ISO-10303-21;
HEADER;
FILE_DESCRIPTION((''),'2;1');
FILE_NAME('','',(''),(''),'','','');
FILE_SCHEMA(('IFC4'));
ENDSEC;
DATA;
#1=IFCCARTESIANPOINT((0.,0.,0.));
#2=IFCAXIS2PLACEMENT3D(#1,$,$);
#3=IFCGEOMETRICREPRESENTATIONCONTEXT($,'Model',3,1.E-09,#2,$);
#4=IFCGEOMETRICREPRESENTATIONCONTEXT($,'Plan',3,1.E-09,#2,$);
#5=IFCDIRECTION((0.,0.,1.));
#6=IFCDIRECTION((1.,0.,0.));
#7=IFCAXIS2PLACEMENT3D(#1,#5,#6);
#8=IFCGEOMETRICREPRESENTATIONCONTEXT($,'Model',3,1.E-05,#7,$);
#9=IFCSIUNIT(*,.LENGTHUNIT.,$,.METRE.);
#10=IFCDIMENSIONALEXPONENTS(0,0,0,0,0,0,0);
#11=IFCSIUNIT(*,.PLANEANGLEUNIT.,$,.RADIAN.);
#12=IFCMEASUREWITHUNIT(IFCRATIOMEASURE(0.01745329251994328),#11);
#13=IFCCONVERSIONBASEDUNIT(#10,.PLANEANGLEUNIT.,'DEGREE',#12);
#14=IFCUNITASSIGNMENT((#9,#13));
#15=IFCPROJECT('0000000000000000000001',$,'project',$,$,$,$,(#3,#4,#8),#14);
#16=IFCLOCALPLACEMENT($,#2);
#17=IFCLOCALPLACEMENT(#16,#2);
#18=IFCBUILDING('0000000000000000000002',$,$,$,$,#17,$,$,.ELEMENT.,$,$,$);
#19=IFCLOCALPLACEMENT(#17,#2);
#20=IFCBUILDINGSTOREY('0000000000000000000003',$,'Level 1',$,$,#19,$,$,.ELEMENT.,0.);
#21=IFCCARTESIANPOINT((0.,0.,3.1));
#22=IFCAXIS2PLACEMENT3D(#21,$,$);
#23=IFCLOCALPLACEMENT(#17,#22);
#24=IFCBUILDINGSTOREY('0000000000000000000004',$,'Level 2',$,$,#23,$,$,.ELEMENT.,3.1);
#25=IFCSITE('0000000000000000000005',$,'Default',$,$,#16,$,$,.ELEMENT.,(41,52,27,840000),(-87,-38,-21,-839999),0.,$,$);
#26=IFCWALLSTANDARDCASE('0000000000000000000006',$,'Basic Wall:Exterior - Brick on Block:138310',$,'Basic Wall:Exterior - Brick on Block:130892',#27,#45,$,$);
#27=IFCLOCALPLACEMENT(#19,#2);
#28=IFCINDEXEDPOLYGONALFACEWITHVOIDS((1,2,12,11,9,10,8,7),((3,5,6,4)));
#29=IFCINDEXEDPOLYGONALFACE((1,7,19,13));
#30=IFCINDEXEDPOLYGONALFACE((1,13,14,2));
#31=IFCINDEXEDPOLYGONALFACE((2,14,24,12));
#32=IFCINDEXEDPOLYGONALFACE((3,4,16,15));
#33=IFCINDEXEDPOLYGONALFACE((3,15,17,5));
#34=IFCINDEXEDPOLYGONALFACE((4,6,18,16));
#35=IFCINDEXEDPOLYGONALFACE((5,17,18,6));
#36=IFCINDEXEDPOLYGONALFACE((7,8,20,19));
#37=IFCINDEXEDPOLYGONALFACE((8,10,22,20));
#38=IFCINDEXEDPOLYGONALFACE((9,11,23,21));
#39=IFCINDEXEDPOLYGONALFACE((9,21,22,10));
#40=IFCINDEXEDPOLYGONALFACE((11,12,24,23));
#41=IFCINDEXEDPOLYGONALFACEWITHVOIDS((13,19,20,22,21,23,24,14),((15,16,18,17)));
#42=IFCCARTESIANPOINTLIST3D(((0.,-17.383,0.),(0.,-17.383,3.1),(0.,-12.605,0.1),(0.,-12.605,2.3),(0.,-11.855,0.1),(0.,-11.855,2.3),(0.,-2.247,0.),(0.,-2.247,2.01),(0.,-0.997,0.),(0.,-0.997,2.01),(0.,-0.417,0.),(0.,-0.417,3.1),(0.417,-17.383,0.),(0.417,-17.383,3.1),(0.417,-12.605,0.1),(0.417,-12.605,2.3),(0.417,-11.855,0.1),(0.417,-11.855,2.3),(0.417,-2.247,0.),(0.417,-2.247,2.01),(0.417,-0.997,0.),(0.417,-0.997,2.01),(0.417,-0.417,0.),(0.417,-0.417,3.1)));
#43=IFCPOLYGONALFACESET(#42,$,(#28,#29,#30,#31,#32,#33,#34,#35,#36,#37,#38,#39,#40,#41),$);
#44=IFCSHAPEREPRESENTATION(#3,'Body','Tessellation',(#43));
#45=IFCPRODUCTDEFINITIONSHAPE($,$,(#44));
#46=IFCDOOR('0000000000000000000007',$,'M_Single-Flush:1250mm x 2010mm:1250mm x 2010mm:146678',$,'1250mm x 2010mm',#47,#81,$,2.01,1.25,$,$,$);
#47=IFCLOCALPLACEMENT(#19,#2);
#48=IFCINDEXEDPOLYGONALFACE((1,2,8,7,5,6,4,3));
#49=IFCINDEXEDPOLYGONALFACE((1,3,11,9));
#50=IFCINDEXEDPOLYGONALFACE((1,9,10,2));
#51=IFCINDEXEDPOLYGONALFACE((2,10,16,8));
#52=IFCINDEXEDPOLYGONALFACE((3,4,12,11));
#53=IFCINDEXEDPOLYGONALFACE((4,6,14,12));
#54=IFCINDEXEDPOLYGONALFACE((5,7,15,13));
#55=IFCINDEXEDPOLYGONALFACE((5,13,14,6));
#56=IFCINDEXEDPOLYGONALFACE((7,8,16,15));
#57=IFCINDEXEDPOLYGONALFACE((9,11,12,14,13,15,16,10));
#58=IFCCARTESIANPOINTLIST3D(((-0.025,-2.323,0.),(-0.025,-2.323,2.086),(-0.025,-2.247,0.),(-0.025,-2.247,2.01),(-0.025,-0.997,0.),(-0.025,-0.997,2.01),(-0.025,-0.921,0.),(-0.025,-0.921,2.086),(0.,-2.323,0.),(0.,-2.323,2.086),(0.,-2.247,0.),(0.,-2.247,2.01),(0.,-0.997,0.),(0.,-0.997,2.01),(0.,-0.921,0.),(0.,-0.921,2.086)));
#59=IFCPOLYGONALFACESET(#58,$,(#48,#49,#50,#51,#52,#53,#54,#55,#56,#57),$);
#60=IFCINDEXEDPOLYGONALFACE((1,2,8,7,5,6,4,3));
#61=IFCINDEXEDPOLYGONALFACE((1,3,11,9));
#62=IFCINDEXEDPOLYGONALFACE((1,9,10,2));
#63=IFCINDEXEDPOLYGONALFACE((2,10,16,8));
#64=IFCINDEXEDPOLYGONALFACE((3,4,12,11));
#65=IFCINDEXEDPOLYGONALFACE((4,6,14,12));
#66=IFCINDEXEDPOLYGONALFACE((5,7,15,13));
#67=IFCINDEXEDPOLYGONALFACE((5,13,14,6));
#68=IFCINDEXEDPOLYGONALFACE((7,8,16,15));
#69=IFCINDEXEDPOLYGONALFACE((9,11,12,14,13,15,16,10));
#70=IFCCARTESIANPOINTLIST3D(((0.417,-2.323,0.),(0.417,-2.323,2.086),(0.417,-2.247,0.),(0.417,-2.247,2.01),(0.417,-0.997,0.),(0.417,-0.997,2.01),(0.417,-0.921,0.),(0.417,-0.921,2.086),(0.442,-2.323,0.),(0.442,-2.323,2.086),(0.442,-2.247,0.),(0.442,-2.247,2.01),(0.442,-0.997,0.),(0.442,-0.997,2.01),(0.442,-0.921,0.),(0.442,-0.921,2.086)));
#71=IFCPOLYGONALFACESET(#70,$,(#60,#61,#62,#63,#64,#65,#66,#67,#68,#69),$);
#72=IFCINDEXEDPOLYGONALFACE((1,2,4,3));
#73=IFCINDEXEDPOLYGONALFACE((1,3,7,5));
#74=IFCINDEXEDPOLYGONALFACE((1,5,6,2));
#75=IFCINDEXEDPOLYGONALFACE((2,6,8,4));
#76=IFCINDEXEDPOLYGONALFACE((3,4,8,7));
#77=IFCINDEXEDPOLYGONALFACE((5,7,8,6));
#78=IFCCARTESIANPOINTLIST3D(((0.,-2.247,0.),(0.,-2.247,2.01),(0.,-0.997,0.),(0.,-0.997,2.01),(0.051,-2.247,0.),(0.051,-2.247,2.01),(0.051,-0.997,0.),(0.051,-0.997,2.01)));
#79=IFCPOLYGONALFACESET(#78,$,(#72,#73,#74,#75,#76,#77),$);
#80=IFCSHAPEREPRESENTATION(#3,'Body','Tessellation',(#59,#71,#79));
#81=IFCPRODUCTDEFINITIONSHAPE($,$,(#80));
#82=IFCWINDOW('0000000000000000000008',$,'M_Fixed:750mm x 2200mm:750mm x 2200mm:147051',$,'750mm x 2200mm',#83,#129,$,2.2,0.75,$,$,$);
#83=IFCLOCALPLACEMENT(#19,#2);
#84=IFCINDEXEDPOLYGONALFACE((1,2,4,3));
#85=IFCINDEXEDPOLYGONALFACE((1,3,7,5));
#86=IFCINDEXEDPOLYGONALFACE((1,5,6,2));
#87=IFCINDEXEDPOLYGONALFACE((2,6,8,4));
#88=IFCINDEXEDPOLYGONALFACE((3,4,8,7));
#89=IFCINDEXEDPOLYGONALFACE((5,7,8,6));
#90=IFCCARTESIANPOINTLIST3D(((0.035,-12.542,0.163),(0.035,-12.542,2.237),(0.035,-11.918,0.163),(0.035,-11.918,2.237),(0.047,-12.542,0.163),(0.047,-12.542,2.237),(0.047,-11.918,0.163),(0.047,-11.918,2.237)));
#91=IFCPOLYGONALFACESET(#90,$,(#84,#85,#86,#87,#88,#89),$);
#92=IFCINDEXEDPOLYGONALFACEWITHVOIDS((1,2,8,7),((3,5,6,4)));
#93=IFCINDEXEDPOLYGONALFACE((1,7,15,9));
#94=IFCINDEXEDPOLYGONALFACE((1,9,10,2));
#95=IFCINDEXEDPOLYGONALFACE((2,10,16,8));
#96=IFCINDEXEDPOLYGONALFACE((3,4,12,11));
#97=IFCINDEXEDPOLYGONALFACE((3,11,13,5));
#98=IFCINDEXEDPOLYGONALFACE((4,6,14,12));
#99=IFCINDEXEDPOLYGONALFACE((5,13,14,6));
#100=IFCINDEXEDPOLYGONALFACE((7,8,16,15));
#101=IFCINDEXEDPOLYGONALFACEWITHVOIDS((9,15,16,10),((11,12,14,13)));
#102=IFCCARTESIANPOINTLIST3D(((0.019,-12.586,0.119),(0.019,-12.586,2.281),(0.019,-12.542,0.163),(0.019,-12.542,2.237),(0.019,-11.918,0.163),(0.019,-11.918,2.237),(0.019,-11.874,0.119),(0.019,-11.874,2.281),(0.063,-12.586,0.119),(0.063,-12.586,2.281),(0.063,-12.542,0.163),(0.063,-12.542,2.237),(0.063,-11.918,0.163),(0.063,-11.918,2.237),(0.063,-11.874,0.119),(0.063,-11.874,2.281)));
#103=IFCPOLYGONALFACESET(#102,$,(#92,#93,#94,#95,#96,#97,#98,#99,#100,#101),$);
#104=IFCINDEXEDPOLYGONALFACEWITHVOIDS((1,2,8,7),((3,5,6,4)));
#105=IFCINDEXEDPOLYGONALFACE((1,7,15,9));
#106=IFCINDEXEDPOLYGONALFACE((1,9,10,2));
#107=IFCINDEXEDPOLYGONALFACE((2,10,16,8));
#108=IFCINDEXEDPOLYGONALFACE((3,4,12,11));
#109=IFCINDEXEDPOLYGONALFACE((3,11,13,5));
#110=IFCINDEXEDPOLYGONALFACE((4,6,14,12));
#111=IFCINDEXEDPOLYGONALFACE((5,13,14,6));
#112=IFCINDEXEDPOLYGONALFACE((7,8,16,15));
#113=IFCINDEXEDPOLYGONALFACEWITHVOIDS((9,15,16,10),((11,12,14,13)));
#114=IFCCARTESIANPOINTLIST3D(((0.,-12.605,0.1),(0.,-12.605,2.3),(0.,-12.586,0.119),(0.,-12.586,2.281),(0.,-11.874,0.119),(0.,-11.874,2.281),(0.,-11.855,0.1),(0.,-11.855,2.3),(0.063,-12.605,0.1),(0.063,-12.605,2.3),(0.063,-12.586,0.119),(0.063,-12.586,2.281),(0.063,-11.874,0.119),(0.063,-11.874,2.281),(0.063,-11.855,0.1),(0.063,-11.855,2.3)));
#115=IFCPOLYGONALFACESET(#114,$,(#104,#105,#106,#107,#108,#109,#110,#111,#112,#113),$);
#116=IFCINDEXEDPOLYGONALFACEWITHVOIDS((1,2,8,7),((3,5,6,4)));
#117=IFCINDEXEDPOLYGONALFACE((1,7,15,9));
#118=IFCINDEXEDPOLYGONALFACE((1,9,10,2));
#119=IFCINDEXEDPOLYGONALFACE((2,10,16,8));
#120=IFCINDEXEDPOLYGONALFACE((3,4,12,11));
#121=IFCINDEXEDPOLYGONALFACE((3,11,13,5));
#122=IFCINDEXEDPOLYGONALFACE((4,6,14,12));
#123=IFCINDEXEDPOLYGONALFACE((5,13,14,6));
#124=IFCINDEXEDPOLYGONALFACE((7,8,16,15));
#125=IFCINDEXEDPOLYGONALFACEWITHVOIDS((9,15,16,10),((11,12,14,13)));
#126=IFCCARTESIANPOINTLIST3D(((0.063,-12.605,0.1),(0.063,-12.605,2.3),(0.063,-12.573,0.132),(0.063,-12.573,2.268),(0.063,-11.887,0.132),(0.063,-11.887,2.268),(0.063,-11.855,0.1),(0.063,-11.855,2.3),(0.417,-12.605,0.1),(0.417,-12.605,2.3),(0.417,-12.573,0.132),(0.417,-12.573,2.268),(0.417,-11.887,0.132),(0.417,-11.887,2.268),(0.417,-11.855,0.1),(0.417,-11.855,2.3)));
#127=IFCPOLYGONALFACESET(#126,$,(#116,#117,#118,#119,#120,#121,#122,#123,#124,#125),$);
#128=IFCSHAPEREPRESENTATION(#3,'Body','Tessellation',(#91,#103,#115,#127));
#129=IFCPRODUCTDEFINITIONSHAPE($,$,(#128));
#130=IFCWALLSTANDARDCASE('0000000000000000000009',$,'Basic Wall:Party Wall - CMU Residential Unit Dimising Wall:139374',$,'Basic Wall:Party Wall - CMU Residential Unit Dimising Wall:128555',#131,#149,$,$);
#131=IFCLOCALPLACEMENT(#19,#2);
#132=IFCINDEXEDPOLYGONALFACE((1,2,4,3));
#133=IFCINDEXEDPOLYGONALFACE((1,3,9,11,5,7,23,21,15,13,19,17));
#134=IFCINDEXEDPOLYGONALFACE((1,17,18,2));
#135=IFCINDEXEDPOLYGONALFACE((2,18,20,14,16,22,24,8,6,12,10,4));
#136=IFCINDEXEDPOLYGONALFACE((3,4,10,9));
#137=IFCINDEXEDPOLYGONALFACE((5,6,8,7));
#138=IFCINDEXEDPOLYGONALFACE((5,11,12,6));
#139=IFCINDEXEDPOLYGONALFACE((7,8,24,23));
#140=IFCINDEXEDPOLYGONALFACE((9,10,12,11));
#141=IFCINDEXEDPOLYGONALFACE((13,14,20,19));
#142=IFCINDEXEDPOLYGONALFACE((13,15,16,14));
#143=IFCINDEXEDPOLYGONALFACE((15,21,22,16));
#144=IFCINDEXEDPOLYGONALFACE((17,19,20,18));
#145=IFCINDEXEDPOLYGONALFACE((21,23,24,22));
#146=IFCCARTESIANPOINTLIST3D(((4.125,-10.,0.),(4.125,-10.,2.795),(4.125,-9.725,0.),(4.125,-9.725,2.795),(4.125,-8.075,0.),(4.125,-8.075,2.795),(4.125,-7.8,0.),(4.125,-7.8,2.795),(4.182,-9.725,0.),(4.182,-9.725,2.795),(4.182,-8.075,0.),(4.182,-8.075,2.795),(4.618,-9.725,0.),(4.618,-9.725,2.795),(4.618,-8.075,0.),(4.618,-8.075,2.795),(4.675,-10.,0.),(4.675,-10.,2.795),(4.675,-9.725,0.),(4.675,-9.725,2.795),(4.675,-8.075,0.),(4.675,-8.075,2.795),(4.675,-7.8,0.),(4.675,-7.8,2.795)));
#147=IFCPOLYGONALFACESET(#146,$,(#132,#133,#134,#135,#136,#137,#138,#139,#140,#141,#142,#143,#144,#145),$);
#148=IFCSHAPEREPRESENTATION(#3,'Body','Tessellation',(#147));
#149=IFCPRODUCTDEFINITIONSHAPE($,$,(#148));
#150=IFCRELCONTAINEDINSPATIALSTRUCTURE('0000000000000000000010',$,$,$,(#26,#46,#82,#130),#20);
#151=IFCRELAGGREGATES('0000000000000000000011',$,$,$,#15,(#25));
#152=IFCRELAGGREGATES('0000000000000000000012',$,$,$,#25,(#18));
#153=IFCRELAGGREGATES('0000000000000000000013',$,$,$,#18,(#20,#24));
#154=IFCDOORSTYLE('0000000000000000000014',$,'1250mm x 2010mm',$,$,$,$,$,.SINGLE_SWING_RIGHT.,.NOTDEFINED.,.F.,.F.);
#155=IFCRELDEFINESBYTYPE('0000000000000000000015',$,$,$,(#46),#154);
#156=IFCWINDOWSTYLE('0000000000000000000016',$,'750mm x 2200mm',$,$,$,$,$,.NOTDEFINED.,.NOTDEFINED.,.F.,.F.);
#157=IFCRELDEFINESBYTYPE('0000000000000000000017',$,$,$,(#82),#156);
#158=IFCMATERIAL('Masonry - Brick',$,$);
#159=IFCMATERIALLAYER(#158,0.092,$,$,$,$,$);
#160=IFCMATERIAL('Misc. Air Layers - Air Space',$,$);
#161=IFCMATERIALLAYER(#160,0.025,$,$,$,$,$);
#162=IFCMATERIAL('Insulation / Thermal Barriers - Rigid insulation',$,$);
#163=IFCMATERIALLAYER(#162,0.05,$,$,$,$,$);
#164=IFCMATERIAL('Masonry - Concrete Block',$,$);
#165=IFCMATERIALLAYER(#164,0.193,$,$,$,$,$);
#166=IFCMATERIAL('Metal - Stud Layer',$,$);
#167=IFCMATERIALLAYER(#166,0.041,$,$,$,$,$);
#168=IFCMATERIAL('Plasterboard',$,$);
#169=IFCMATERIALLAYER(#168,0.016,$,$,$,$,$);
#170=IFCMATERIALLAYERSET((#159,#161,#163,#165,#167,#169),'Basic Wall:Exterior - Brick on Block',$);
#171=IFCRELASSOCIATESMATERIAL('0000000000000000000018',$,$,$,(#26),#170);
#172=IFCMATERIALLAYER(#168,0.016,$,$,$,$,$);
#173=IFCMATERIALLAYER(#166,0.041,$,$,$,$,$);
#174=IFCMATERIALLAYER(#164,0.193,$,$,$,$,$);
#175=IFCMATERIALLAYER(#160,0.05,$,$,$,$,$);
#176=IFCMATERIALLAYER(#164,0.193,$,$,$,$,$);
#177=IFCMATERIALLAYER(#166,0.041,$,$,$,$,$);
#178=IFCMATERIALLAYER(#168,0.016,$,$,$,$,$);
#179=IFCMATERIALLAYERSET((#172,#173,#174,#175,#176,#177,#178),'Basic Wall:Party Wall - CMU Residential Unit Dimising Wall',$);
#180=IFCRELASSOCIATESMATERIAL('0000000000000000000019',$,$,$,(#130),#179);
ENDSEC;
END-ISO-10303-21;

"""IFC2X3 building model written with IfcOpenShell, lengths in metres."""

from ifc_helpers import new_model, entity, si_unit, converted_unit, frame, frame_2d, origin, origin_with_axes, origin_2d_with_axis, place, context, project, spatial, polyline, rectangle, outline, extrude, clip, bounded_halfspace, source, transform, mapped, material, layer, layer_set, layer_usage, type_object, type_shapes, element, fill, save


model = new_model("IFC2X3")

# Units and contexts
model_context_1 = context("Model", 3, precision=1e-09, world=origin())
plan_context = context("Plan", 3, precision=1e-09, world=origin())
model_context_2 = context("Model", 3, precision=1e-05, world=origin_with_axes())
ifc_project = project(units=[si_unit("LENGTHUNIT", "METRE"), converted_unit("PLANEANGLEUNIT", "DEGREE", entity("IfcRatioMeasure", 0.01745329251994328), si_unit("PLANEANGLEUNIT", "RADIAN"), dimensions=[0, 0, 0, 0, 0, 0, 0])], contexts=[model_context_1, plan_context, model_context_2])

# Site, building, storey
site_placement = place(None, origin())
site = spatial("IfcSite", under=ifc_project, at=site_placement, Name="Default", CompositionType="ELEMENT", RefLatitude=(41, 52, 27, 840000), RefLongitude=(-87, -38, -21, -839999), RefElevation=0.0)
building_placement = place(site_placement, origin())
building = spatial("IfcBuilding", under=site, at=building_placement, CompositionType="ELEMENT")
storey_1_placement = place(building_placement, origin())
storey_1 = spatial("IfcBuildingStorey", under=building, at=storey_1_placement, Name="Level 1", CompositionType="ELEMENT", Elevation=0.0)

# Shared definitions
ifc_material_1 = material(Name="Masonry - Brick")
ifc_layer_1 = layer(ifc_material_1, 0.092)
ifc_material_2 = material(Name="Misc. Air Layers - Air Space")
ifc_layer_2 = layer(ifc_material_2, 0.025)
ifc_material_3 = material(Name="Insulation / Thermal Barriers - Rigid insulation")
ifc_layer_3 = layer(ifc_material_3, 0.05)
ifc_material_4 = material(Name="Masonry - Concrete Block")
ifc_layer_4 = layer(ifc_material_4, 0.193)
ifc_material_5 = material(Name="Metal - Stud Layer")
ifc_layer_5 = layer(ifc_material_5, 0.041)
ifc_material_6 = material(Name="Plasterboard")
ifc_layer_6 = layer(ifc_material_6, 0.016)
ifc_layer_set_1 = layer_set([ifc_layer_1, ifc_layer_2, ifc_layer_3, ifc_layer_4, ifc_layer_5, ifc_layer_6], Name="Basic Wall:Exterior - Brick on Block")

# Wall, openings, door, window
ifc_layer_usage_1 = layer_usage(ifc_layer_set_1, "AXIS2", "NEGATIVE", 0.2085)
wall_1_placement = place(storey_1_placement, frame((0.2085, -17.383, 0.0), z_axis=(0.0, 0.0, 1.0), x_axis=(0.0, 1.0, 0.0)))
wall_1 = element("IfcWallStandardCase", 1, at=wall_1_placement, inside=storey_1, material=ifc_layer_usage_1, Name="Basic Wall:Exterior - Brick on Block:138310", ObjectType="Basic Wall:Exterior - Brick on Block:130892", context=model_context_1, shape_type="SweptSolid", body=[
    extrude(rectangle(XDim=16.966, YDim=0.417, at=frame_2d((8.483, 0.0), x_axis=(-1.0, 0.0))), origin(), (0.0, 0.0, 1.0), 3.1),
])
opening_1_placement = place(wall_1_placement, frame((15.136, -0.2085, 0.0)))
opening_1 = element("IfcOpeningElement", 2, at=opening_1_placement, cuts=wall_1, ObjectType="Opening", context=model_context_1, shape_type="SweptSolid", body=[
    extrude(rectangle(XDim=1.25, YDim=2.01, at=frame_2d((1.005, 0.625), x_axis=(0.0, 1.0))), frame((0.0, 0.0, 0.0), z_axis=(0.0, 1.0, 0.0), x_axis=(0.0, 0.0, 1.0)), (0.0, 0.0, 1.0), 0.417),
])
opening_2_placement = place(wall_1_placement, frame((4.778, -0.2085, 0.1)))
opening_2 = element("IfcOpeningElement", 3, at=opening_2_placement, cuts=wall_1, ObjectType="Opening", context=model_context_1, shape_type="SweptSolid", body=[
    extrude(rectangle(XDim=2.2, YDim=0.75, at=frame_2d((1.1, 0.375), x_axis=(1.0, 0.0))), frame((0.0, 0.0, 0.0), z_axis=(0.0, 1.0, 0.0), x_axis=(0.0, 0.0, 1.0)), (0.0, 0.0, 1.0), 0.417),
])
door_style_1 = type_object("IfcDoorStyle", Name="1250mm x 2010mm", ConstructionType="NOTDEFINED", OperationType="SINGLE_SWING_RIGHT", ParameterTakesPrecedence=False, Sizeable=False)
shared_shape_1 = source(origin(), model_context_1, "Body", "SweptSolid", [
    extrude(outline(polyline([(-0.701, -1.062), (0.701, -1.062), (0.701, 1.024), (0.625, 1.024), (0.625, -0.986), (-0.625, -0.986), (-0.625, 1.024), (-0.701, 1.024), (-0.701, -1.062)])), frame((0.625, 0.417, 1.024), z_axis=(0.0, 1.0, 0.0), x_axis=(1.0, 0.0, 0.0)), (0.0, 0.0, 1.0), 0.025),
    extrude(outline(polyline([(-1.062, -0.701), (1.024, -0.701), (1.024, -0.625), (-0.986, -0.625), (-0.986, 0.625), (1.024, 0.625), (1.024, 0.701), (-1.062, 0.701), (-1.062, -0.701)])), frame((0.625, -0.025, 1.024), z_axis=(0.0, 1.0, 0.0), x_axis=(0.0, 0.0, -1.0)), (0.0, 0.0, 1.0), 0.025),
    extrude(rectangle(XDim=0.051, YDim=1.25, at=origin_2d_with_axis()), frame((0.625, 0.3915, 0.0), z_axis=(0.0, 0.0, 1.0), x_axis=(0.0, 1.0, 0.0)), (0.0, 0.0, 1.0), 2.01),
])
type_shapes(door_style_1, [shared_shape_1])
door_1_placement = place(opening_1_placement, origin())
door_1 = element("IfcDoor", 4, at=door_1_placement, inside=storey_1, type_object=door_style_1, Name="M_Single-Flush:1250mm x 2010mm:1250mm x 2010mm:146678", ObjectType="1250mm x 2010mm", OverallHeight=2.01, OverallWidth=1.25, context=model_context_1, shape_type="MappedRepresentation", body=[
    mapped(shared_shape_1, transform((0.0, 0.0, 0.0), scale=1.0)),
])
fill(opening_1, door_1)
window_style_1 = type_object("IfcWindowStyle", Name="750mm x 2200mm", ConstructionType="NOTDEFINED", OperationType="NOTDEFINED", ParameterTakesPrecedence=False, Sizeable=False)
shared_shape_2 = source(origin(), model_context_1, "Body", "SweptSolid", [
    extrude(rectangle(XDim=0.012, YDim=0.624, at=origin_2d_with_axis()), frame((0.375, 0.376, 0.063), z_axis=(0.0, 0.0, 1.0), x_axis=(0.0, -1.0, 0.0)), (0.0, 0.0, 1.0), 2.074),
    extrude(outline(polyline([(-0.356, -1.081), (0.356, -1.081), (0.356, 1.081), (-0.356, 1.081), (-0.356, -1.081)]), holes=[polyline([(-0.312, -1.037), (-0.312, 1.037), (0.312, 1.037), (0.312, -1.037), (-0.312, -1.037)])]), frame((0.375, 0.354, 1.1), z_axis=(0.0, 1.0, 0.0), x_axis=(1.0, 0.0, 0.0)), (0.0, 0.0, 1.0), 0.044),
    extrude(outline(polyline([(-0.375, -1.1), (0.375, -1.1), (0.375, 1.1), (-0.375, 1.1), (-0.375, -1.1)]), holes=[polyline([(-0.356, -1.081), (-0.356, 1.081), (0.356, 1.081), (0.356, -1.081), (-0.356, -1.081)])]), frame((0.375, 0.354, 1.1), z_axis=(0.0, 1.0, 0.0), x_axis=(1.0, 0.0, 0.0)), (0.0, 0.0, 1.0), 0.063),
    extrude(outline(polyline([(-0.375, -1.1), (0.375, -1.1), (0.375, 1.1), (-0.375, 1.1), (-0.375, -1.1)]), holes=[polyline([(-0.343, -1.068), (-0.343, 1.068), (0.343, 1.068), (0.343, -1.068), (-0.343, -1.068)])]), frame((0.375, 0.0, 1.1), z_axis=(0.0, 1.0, 0.0), x_axis=(1.0, 0.0, 0.0)), (0.0, 0.0, 1.0), 0.354),
])
type_shapes(window_style_1, [shared_shape_2])
window_1_placement = place(opening_2_placement, origin())
window_1 = element("IfcWindow", 5, at=window_1_placement, inside=storey_1, type_object=window_style_1, Name="M_Fixed:750mm x 2200mm:750mm x 2200mm:147051", ObjectType="750mm x 2200mm", OverallHeight=2.2, OverallWidth=0.75, context=model_context_1, shape_type="MappedRepresentation", body=[
    mapped(shared_shape_2, transform((0.0, 0.0, 0.0), scale=1.0)),
])
fill(opening_2, window_1)

# Wall
ifc_layer_7 = layer(ifc_material_6, 0.016)
ifc_layer_8 = layer(ifc_material_5, 0.041)
ifc_layer_9 = layer(ifc_material_4, 0.193)
ifc_layer_10 = layer(ifc_material_2, 0.05)
ifc_layer_11 = layer(ifc_material_4, 0.193)
ifc_layer_12 = layer(ifc_material_5, 0.041)
ifc_layer_13 = layer(ifc_material_6, 0.016)
ifc_layer_set_2 = layer_set([ifc_layer_7, ifc_layer_8, ifc_layer_9, ifc_layer_10, ifc_layer_11, ifc_layer_12, ifc_layer_13], Name="Basic Wall:Party Wall - CMU Residential Unit Dimising Wall")
ifc_layer_usage_2 = layer_usage(ifc_layer_set_2, "AXIS2", "NEGATIVE", 0.275)
wall_2_placement = place(storey_1_placement, frame((4.4, -10.0, 0.0), z_axis=(0.0, 0.0, 1.0), x_axis=(0.0, 1.0, 0.0)))
element("IfcWallStandardCase", 6, at=wall_2_placement, inside=storey_1, material=ifc_layer_usage_2, Name="Basic Wall:Party Wall - CMU Residential Unit Dimising Wall:139374", ObjectType="Basic Wall:Party Wall - CMU Residential Unit Dimising Wall:128555", context=model_context_1, shape_type="Clipping", body=[
    clip(clip(extrude(rectangle(XDim=2.2, YDim=0.55, at=frame_2d((1.1, 0.0), x_axis=(-1.0, 0.0))), origin(), (0.0, 0.0, 1.0), 2.795), bounded_halfspace(frame((1.925, 0.218, 0.0), z_axis=(0.0, -1.0, 0.0), x_axis=(1.0, 0.0, 0.0)), True, frame((1.925, 0.218, 0.0), z_axis=(0.0, -1.0, 0.0), x_axis=(1.0, 0.0, 0.0)), polyline([(0.0, 0.0), (0.0, 2.795), (-1.65, 2.795), (-1.65, 0.0), (0.0, 0.0)]))), bounded_halfspace(frame((0.275, -0.218, 0.0), z_axis=(0.0, 1.0, 0.0), x_axis=(-1.0, 0.0, 0.0)), True, frame((0.275, -0.218, 0.0), z_axis=(0.0, 1.0, 0.0), x_axis=(-1.0, 0.0, 0.0)), polyline([(0.0, 0.0), (0.0, 2.795), (-1.65, 2.795), (-1.65, 0.0), (0.0, 0.0)]))),
])

# Shared definitions
storey_2_placement = place(building_placement, frame((0.0, 0.0, 3.1)))
storey_2 = spatial("IfcBuildingStorey", under=building, at=storey_2_placement, Name="Level 2", CompositionType="ELEMENT", Elevation=3.1)

save(model, "model.ifc")
